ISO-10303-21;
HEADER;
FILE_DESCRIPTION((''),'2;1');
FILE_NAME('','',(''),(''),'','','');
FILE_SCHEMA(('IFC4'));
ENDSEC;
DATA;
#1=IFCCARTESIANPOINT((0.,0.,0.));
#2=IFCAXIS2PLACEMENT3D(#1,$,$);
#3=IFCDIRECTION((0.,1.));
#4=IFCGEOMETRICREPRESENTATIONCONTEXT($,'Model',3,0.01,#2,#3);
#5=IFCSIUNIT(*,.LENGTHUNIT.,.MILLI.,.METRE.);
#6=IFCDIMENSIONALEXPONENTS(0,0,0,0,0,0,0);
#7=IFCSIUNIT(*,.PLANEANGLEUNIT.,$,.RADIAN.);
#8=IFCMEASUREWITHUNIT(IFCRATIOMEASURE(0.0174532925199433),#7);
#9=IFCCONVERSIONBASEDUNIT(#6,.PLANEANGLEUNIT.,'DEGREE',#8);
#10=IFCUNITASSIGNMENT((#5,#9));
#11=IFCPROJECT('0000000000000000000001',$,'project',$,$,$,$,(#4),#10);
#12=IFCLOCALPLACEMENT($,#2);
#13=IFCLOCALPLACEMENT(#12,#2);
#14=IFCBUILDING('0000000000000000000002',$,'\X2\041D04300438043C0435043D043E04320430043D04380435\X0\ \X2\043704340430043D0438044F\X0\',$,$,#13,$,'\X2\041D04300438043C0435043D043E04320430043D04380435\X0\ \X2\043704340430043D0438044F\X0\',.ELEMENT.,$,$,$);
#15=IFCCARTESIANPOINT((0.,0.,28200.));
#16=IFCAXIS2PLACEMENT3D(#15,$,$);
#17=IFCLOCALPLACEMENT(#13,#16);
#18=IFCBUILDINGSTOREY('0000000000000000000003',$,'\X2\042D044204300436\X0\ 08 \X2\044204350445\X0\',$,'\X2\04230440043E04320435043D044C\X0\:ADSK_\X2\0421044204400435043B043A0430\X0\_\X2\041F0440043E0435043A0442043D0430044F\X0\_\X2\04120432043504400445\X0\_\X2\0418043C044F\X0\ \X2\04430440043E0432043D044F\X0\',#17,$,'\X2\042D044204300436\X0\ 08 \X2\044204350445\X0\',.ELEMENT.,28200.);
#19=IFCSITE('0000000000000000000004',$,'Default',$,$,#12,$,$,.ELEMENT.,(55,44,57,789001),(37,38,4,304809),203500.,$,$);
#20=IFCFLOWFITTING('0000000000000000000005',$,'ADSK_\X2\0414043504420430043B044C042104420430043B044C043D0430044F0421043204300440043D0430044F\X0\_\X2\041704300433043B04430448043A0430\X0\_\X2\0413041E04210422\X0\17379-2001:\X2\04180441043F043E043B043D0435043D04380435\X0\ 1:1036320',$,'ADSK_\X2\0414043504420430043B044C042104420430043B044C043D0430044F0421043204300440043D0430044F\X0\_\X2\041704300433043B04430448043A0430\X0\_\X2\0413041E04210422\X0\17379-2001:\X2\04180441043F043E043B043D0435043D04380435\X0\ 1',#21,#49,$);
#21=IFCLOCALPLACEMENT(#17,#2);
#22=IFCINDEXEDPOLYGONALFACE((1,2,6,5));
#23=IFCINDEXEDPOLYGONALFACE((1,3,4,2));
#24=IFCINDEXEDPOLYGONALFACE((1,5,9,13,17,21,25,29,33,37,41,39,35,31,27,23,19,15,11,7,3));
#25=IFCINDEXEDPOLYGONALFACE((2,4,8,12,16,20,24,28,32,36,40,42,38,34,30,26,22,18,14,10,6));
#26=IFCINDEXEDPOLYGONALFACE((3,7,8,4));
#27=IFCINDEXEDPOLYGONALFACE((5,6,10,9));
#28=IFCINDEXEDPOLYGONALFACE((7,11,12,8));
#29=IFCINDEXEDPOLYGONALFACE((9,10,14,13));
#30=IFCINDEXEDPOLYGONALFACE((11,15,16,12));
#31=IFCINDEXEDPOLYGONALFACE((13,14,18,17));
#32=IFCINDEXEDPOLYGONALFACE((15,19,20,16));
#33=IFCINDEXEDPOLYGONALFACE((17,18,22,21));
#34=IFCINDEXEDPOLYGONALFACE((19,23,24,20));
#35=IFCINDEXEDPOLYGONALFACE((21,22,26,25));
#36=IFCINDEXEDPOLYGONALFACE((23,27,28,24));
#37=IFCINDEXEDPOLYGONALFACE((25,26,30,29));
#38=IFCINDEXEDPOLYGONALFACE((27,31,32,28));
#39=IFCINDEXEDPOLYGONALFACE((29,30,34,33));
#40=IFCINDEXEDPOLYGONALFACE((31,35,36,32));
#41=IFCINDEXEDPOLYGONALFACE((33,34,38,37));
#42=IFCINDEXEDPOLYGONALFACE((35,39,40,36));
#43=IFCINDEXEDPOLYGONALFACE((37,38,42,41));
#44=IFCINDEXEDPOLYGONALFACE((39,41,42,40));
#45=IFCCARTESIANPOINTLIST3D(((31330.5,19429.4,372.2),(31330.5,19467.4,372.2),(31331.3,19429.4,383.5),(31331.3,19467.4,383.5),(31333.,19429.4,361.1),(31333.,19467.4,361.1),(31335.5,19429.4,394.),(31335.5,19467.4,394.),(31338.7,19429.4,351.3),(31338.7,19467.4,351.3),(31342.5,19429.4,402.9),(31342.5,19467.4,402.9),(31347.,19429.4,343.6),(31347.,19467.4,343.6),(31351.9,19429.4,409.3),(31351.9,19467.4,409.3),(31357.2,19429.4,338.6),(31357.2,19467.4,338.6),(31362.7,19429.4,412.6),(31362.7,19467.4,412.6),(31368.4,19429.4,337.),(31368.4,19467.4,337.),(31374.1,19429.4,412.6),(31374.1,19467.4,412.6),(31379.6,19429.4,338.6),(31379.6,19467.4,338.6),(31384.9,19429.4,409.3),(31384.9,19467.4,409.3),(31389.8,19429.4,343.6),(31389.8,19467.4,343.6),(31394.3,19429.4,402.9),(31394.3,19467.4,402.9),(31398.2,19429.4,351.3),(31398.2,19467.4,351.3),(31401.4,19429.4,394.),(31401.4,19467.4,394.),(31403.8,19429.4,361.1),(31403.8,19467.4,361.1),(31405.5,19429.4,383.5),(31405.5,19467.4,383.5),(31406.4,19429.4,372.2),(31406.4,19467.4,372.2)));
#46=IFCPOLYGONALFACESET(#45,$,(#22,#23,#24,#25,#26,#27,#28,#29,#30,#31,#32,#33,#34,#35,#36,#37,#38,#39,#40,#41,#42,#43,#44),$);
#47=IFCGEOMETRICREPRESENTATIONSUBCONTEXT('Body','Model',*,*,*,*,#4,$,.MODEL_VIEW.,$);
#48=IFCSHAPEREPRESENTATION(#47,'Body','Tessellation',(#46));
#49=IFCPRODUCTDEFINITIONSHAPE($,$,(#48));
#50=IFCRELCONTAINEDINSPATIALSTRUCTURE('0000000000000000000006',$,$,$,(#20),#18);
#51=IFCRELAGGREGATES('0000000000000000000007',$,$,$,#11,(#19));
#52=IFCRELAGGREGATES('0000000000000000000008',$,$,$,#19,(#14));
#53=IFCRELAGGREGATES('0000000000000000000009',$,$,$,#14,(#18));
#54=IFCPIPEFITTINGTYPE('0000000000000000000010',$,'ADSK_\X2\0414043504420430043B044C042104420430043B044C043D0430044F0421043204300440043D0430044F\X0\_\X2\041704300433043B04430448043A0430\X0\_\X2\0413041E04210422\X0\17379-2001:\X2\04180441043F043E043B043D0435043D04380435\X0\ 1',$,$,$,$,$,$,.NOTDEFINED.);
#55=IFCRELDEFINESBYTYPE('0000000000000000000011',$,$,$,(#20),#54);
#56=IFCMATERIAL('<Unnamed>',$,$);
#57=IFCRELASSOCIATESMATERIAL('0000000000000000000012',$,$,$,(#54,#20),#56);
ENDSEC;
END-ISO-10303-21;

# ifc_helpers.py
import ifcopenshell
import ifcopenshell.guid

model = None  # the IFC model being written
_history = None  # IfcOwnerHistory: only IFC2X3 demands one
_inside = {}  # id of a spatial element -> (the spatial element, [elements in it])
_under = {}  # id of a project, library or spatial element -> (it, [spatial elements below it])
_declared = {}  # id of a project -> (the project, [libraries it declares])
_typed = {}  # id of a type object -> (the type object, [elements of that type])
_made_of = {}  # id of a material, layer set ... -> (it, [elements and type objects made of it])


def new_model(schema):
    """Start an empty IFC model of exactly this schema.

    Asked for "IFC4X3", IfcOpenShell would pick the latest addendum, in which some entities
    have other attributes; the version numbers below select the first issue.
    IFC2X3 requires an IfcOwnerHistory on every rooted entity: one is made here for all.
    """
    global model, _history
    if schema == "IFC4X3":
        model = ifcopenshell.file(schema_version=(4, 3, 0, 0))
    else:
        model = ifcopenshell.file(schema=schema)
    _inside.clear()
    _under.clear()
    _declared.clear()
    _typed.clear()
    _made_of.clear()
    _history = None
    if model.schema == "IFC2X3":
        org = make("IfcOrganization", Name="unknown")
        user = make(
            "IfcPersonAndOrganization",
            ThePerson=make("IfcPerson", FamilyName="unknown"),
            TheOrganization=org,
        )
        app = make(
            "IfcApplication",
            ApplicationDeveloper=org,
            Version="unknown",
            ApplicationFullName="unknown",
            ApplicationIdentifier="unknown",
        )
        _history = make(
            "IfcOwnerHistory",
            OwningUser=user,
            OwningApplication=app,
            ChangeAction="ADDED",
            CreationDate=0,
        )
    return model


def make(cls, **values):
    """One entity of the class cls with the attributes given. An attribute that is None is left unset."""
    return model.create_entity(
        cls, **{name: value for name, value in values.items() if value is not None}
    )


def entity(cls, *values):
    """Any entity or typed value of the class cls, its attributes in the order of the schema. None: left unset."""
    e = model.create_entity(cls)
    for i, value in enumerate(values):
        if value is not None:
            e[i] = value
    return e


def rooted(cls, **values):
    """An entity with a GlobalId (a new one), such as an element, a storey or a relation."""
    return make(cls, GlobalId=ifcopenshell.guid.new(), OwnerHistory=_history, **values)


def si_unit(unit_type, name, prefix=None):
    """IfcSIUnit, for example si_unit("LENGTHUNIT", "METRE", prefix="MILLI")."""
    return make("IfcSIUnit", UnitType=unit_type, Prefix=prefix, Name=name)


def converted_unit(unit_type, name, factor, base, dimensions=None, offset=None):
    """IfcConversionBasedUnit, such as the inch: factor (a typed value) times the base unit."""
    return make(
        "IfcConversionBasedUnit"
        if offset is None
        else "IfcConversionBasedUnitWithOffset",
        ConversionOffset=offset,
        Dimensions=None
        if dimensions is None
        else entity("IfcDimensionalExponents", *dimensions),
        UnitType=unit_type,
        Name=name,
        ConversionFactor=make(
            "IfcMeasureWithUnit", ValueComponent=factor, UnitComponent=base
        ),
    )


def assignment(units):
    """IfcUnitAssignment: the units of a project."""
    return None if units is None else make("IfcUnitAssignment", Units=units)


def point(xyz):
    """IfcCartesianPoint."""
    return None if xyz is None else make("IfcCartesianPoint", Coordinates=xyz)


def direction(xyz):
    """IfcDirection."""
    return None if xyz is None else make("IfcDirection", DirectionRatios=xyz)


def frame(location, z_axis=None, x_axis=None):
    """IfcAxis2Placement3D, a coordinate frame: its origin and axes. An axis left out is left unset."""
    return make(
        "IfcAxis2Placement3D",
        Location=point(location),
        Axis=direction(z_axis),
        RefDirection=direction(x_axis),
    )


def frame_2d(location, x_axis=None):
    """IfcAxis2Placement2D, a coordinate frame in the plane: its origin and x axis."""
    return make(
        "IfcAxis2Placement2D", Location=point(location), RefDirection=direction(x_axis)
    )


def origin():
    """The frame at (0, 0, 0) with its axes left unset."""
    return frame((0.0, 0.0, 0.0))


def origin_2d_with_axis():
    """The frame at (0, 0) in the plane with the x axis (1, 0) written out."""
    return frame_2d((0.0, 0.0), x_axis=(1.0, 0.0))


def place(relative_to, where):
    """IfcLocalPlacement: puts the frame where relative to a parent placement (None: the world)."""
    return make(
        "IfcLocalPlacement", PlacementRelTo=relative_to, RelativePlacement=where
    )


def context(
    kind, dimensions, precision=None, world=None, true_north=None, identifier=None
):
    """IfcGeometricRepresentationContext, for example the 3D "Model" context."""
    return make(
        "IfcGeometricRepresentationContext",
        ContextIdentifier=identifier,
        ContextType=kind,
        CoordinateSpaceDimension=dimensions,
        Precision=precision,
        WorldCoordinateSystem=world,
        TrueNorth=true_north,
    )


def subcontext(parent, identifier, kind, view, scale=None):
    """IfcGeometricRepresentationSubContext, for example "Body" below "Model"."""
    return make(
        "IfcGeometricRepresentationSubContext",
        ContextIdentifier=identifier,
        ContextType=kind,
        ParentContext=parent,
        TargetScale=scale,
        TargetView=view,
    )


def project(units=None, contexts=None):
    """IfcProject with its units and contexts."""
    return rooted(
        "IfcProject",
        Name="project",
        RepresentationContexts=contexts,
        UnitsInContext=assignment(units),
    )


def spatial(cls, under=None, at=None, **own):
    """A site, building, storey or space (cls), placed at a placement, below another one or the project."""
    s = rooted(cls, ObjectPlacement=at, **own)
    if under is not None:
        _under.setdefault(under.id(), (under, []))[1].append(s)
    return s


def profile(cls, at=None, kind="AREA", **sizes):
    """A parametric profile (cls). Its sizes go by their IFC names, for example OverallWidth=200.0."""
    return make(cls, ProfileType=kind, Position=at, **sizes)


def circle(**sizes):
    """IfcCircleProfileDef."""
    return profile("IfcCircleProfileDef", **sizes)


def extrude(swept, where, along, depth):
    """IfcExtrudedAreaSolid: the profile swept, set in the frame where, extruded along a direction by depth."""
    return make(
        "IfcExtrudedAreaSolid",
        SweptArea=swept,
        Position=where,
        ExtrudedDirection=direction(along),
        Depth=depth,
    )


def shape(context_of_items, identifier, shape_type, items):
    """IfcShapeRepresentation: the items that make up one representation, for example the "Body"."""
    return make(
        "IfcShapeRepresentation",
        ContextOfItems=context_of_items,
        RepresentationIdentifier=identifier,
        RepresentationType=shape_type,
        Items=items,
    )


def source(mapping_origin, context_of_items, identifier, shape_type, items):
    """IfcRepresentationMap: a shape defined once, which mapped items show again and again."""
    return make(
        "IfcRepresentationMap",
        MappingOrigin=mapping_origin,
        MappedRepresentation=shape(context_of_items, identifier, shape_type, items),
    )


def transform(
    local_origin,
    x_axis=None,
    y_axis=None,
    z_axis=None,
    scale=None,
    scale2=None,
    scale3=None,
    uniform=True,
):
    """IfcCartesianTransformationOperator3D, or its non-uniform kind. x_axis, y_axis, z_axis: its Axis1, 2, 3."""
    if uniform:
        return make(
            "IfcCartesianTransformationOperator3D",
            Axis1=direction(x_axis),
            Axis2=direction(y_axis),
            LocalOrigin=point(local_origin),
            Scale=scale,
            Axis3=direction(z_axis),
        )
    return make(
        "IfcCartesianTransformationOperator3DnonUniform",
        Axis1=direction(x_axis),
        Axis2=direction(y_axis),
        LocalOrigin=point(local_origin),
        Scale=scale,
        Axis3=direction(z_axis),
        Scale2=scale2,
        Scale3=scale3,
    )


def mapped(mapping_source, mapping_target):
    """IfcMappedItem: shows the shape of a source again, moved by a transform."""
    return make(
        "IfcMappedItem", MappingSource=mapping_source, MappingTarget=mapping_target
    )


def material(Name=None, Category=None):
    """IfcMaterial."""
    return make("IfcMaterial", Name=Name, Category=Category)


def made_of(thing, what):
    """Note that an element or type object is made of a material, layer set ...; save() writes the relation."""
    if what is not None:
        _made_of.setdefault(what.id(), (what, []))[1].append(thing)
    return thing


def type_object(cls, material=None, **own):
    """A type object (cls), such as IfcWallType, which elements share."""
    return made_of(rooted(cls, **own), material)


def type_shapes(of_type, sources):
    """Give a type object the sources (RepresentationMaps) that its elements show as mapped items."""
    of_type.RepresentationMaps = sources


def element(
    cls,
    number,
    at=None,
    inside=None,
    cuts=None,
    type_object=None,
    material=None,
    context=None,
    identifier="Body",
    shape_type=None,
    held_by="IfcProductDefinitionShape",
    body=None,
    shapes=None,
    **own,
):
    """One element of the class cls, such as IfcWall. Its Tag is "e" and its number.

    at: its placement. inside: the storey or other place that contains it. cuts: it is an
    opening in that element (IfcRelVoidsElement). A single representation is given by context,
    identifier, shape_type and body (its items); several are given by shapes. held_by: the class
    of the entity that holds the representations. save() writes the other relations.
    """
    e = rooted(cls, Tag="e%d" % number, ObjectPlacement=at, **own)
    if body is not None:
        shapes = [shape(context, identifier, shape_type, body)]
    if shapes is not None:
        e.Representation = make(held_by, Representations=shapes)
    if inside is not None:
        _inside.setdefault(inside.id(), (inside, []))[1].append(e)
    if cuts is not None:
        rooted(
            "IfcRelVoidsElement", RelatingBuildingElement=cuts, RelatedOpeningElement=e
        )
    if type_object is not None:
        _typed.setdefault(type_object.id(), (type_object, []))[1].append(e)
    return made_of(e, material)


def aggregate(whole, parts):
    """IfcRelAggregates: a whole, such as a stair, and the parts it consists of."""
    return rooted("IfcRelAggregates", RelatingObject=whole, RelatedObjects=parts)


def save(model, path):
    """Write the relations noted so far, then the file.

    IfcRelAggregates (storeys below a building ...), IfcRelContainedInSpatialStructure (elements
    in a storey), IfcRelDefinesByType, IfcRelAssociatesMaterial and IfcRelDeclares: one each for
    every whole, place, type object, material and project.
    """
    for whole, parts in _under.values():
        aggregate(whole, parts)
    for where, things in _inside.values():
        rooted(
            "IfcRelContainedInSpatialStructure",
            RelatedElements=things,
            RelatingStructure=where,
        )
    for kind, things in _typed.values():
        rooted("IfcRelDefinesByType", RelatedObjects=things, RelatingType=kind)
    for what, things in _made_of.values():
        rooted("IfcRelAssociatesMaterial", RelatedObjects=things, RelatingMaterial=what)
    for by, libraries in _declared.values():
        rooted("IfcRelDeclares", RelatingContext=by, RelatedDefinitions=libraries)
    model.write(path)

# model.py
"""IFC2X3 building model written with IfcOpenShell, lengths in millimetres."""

from ifc_helpers import new_model, entity, si_unit, converted_unit, direction, frame, origin, origin_2d_with_axis, place, context, subcontext, project, spatial, circle, extrude, source, transform, mapped, material, type_object, type_shapes, element, save


model = new_model("IFC2X3")

# Units and contexts
model_context = context("Model", 3, precision=0.01, world=origin(), true_north=direction((0.0, 1.0)))
body_context = subcontext(model_context, "Body", "Model", "MODEL_VIEW")
ifc_project = project(units=[si_unit("LENGTHUNIT", "METRE", prefix="MILLI"), converted_unit("PLANEANGLEUNIT", "DEGREE", entity("IfcRatioMeasure", 0.0174532925199433), si_unit("PLANEANGLEUNIT", "RADIAN"), dimensions=[0, 0, 0, 0, 0, 0, 0])], contexts=[model_context])

# Site, building, storey
site_placement = place(None, origin())
site = spatial("IfcSite", under=ifc_project, at=site_placement, Name="Default", CompositionType="ELEMENT", RefLatitude=(55, 44, 57, 789001), RefLongitude=(37, 38, 4, 304809), RefElevation=203500.0)
building_placement = place(site_placement, origin())
building = spatial("IfcBuilding", under=site, at=building_placement, Name="Наименование здания", LongName="Наименование здания", CompositionType="ELEMENT")
storey_placement = place(building_placement, frame((0.0, 0.0, 28200.0)))
storey = spatial("IfcBuildingStorey", under=building, at=storey_placement, Name="Этаж 08 тех", ObjectType="Уровень:ADSK_Стрелка_Проектная_Вверх_Имя уровня", LongName="Этаж 08 тех", CompositionType="ELEMENT", Elevation=28200.0)

# Shared definitions
ifc_material = material(Name="<Unnamed>")

# Flow fitting
pipe_fitting_type_1 = type_object("IfcPipeFittingType", Name="ADSK_ДетальСтальнаяСварная_Заглушка_ГОСТ17379-2001:Исполнение 1", PredefinedType="NOTDEFINED", material=ifc_material)
shared_shape_1 = source(origin(), body_context, "Body", "SweptSolid", [
    extrude(circle(Radius=38.0, at=origin_2d_with_axis()), frame((0.0, 0.0, 0.0), z_axis=(1.0, 0.0, 0.0), x_axis=(0.0, 1.0, 0.0)), (0.0, 0.0, 1.0), 38.0),
])
type_shapes(pipe_fitting_type_1, [shared_shape_1])
for number, where, z_axis, x_axis, name in (
    (1, (31368.4, 19429.4, 375.0), (-1.0, 0.0, 0.0), (0.0, 1.0, 0.0), "ADSK_ДетальСтальнаяСварная_Заглушка_ГОСТ17379-2001:Исполнение 1:1036320"),
):
    element("IfcFlowFitting", number, at=place(storey_placement, frame(where, z_axis=z_axis, x_axis=x_axis)), inside=storey, type_object=pipe_fitting_type_1, material=ifc_material, Name=name, ObjectType="ADSK_ДетальСтальнаяСварная_Заглушка_ГОСТ17379-2001:Исполнение 1", context=body_context, shape_type="MappedRepresentation", body=[
        mapped(shared_shape_1, transform((0.0, 0.0, 0.0), scale=1.0)),
    ])

save(model, "model.ifc")
